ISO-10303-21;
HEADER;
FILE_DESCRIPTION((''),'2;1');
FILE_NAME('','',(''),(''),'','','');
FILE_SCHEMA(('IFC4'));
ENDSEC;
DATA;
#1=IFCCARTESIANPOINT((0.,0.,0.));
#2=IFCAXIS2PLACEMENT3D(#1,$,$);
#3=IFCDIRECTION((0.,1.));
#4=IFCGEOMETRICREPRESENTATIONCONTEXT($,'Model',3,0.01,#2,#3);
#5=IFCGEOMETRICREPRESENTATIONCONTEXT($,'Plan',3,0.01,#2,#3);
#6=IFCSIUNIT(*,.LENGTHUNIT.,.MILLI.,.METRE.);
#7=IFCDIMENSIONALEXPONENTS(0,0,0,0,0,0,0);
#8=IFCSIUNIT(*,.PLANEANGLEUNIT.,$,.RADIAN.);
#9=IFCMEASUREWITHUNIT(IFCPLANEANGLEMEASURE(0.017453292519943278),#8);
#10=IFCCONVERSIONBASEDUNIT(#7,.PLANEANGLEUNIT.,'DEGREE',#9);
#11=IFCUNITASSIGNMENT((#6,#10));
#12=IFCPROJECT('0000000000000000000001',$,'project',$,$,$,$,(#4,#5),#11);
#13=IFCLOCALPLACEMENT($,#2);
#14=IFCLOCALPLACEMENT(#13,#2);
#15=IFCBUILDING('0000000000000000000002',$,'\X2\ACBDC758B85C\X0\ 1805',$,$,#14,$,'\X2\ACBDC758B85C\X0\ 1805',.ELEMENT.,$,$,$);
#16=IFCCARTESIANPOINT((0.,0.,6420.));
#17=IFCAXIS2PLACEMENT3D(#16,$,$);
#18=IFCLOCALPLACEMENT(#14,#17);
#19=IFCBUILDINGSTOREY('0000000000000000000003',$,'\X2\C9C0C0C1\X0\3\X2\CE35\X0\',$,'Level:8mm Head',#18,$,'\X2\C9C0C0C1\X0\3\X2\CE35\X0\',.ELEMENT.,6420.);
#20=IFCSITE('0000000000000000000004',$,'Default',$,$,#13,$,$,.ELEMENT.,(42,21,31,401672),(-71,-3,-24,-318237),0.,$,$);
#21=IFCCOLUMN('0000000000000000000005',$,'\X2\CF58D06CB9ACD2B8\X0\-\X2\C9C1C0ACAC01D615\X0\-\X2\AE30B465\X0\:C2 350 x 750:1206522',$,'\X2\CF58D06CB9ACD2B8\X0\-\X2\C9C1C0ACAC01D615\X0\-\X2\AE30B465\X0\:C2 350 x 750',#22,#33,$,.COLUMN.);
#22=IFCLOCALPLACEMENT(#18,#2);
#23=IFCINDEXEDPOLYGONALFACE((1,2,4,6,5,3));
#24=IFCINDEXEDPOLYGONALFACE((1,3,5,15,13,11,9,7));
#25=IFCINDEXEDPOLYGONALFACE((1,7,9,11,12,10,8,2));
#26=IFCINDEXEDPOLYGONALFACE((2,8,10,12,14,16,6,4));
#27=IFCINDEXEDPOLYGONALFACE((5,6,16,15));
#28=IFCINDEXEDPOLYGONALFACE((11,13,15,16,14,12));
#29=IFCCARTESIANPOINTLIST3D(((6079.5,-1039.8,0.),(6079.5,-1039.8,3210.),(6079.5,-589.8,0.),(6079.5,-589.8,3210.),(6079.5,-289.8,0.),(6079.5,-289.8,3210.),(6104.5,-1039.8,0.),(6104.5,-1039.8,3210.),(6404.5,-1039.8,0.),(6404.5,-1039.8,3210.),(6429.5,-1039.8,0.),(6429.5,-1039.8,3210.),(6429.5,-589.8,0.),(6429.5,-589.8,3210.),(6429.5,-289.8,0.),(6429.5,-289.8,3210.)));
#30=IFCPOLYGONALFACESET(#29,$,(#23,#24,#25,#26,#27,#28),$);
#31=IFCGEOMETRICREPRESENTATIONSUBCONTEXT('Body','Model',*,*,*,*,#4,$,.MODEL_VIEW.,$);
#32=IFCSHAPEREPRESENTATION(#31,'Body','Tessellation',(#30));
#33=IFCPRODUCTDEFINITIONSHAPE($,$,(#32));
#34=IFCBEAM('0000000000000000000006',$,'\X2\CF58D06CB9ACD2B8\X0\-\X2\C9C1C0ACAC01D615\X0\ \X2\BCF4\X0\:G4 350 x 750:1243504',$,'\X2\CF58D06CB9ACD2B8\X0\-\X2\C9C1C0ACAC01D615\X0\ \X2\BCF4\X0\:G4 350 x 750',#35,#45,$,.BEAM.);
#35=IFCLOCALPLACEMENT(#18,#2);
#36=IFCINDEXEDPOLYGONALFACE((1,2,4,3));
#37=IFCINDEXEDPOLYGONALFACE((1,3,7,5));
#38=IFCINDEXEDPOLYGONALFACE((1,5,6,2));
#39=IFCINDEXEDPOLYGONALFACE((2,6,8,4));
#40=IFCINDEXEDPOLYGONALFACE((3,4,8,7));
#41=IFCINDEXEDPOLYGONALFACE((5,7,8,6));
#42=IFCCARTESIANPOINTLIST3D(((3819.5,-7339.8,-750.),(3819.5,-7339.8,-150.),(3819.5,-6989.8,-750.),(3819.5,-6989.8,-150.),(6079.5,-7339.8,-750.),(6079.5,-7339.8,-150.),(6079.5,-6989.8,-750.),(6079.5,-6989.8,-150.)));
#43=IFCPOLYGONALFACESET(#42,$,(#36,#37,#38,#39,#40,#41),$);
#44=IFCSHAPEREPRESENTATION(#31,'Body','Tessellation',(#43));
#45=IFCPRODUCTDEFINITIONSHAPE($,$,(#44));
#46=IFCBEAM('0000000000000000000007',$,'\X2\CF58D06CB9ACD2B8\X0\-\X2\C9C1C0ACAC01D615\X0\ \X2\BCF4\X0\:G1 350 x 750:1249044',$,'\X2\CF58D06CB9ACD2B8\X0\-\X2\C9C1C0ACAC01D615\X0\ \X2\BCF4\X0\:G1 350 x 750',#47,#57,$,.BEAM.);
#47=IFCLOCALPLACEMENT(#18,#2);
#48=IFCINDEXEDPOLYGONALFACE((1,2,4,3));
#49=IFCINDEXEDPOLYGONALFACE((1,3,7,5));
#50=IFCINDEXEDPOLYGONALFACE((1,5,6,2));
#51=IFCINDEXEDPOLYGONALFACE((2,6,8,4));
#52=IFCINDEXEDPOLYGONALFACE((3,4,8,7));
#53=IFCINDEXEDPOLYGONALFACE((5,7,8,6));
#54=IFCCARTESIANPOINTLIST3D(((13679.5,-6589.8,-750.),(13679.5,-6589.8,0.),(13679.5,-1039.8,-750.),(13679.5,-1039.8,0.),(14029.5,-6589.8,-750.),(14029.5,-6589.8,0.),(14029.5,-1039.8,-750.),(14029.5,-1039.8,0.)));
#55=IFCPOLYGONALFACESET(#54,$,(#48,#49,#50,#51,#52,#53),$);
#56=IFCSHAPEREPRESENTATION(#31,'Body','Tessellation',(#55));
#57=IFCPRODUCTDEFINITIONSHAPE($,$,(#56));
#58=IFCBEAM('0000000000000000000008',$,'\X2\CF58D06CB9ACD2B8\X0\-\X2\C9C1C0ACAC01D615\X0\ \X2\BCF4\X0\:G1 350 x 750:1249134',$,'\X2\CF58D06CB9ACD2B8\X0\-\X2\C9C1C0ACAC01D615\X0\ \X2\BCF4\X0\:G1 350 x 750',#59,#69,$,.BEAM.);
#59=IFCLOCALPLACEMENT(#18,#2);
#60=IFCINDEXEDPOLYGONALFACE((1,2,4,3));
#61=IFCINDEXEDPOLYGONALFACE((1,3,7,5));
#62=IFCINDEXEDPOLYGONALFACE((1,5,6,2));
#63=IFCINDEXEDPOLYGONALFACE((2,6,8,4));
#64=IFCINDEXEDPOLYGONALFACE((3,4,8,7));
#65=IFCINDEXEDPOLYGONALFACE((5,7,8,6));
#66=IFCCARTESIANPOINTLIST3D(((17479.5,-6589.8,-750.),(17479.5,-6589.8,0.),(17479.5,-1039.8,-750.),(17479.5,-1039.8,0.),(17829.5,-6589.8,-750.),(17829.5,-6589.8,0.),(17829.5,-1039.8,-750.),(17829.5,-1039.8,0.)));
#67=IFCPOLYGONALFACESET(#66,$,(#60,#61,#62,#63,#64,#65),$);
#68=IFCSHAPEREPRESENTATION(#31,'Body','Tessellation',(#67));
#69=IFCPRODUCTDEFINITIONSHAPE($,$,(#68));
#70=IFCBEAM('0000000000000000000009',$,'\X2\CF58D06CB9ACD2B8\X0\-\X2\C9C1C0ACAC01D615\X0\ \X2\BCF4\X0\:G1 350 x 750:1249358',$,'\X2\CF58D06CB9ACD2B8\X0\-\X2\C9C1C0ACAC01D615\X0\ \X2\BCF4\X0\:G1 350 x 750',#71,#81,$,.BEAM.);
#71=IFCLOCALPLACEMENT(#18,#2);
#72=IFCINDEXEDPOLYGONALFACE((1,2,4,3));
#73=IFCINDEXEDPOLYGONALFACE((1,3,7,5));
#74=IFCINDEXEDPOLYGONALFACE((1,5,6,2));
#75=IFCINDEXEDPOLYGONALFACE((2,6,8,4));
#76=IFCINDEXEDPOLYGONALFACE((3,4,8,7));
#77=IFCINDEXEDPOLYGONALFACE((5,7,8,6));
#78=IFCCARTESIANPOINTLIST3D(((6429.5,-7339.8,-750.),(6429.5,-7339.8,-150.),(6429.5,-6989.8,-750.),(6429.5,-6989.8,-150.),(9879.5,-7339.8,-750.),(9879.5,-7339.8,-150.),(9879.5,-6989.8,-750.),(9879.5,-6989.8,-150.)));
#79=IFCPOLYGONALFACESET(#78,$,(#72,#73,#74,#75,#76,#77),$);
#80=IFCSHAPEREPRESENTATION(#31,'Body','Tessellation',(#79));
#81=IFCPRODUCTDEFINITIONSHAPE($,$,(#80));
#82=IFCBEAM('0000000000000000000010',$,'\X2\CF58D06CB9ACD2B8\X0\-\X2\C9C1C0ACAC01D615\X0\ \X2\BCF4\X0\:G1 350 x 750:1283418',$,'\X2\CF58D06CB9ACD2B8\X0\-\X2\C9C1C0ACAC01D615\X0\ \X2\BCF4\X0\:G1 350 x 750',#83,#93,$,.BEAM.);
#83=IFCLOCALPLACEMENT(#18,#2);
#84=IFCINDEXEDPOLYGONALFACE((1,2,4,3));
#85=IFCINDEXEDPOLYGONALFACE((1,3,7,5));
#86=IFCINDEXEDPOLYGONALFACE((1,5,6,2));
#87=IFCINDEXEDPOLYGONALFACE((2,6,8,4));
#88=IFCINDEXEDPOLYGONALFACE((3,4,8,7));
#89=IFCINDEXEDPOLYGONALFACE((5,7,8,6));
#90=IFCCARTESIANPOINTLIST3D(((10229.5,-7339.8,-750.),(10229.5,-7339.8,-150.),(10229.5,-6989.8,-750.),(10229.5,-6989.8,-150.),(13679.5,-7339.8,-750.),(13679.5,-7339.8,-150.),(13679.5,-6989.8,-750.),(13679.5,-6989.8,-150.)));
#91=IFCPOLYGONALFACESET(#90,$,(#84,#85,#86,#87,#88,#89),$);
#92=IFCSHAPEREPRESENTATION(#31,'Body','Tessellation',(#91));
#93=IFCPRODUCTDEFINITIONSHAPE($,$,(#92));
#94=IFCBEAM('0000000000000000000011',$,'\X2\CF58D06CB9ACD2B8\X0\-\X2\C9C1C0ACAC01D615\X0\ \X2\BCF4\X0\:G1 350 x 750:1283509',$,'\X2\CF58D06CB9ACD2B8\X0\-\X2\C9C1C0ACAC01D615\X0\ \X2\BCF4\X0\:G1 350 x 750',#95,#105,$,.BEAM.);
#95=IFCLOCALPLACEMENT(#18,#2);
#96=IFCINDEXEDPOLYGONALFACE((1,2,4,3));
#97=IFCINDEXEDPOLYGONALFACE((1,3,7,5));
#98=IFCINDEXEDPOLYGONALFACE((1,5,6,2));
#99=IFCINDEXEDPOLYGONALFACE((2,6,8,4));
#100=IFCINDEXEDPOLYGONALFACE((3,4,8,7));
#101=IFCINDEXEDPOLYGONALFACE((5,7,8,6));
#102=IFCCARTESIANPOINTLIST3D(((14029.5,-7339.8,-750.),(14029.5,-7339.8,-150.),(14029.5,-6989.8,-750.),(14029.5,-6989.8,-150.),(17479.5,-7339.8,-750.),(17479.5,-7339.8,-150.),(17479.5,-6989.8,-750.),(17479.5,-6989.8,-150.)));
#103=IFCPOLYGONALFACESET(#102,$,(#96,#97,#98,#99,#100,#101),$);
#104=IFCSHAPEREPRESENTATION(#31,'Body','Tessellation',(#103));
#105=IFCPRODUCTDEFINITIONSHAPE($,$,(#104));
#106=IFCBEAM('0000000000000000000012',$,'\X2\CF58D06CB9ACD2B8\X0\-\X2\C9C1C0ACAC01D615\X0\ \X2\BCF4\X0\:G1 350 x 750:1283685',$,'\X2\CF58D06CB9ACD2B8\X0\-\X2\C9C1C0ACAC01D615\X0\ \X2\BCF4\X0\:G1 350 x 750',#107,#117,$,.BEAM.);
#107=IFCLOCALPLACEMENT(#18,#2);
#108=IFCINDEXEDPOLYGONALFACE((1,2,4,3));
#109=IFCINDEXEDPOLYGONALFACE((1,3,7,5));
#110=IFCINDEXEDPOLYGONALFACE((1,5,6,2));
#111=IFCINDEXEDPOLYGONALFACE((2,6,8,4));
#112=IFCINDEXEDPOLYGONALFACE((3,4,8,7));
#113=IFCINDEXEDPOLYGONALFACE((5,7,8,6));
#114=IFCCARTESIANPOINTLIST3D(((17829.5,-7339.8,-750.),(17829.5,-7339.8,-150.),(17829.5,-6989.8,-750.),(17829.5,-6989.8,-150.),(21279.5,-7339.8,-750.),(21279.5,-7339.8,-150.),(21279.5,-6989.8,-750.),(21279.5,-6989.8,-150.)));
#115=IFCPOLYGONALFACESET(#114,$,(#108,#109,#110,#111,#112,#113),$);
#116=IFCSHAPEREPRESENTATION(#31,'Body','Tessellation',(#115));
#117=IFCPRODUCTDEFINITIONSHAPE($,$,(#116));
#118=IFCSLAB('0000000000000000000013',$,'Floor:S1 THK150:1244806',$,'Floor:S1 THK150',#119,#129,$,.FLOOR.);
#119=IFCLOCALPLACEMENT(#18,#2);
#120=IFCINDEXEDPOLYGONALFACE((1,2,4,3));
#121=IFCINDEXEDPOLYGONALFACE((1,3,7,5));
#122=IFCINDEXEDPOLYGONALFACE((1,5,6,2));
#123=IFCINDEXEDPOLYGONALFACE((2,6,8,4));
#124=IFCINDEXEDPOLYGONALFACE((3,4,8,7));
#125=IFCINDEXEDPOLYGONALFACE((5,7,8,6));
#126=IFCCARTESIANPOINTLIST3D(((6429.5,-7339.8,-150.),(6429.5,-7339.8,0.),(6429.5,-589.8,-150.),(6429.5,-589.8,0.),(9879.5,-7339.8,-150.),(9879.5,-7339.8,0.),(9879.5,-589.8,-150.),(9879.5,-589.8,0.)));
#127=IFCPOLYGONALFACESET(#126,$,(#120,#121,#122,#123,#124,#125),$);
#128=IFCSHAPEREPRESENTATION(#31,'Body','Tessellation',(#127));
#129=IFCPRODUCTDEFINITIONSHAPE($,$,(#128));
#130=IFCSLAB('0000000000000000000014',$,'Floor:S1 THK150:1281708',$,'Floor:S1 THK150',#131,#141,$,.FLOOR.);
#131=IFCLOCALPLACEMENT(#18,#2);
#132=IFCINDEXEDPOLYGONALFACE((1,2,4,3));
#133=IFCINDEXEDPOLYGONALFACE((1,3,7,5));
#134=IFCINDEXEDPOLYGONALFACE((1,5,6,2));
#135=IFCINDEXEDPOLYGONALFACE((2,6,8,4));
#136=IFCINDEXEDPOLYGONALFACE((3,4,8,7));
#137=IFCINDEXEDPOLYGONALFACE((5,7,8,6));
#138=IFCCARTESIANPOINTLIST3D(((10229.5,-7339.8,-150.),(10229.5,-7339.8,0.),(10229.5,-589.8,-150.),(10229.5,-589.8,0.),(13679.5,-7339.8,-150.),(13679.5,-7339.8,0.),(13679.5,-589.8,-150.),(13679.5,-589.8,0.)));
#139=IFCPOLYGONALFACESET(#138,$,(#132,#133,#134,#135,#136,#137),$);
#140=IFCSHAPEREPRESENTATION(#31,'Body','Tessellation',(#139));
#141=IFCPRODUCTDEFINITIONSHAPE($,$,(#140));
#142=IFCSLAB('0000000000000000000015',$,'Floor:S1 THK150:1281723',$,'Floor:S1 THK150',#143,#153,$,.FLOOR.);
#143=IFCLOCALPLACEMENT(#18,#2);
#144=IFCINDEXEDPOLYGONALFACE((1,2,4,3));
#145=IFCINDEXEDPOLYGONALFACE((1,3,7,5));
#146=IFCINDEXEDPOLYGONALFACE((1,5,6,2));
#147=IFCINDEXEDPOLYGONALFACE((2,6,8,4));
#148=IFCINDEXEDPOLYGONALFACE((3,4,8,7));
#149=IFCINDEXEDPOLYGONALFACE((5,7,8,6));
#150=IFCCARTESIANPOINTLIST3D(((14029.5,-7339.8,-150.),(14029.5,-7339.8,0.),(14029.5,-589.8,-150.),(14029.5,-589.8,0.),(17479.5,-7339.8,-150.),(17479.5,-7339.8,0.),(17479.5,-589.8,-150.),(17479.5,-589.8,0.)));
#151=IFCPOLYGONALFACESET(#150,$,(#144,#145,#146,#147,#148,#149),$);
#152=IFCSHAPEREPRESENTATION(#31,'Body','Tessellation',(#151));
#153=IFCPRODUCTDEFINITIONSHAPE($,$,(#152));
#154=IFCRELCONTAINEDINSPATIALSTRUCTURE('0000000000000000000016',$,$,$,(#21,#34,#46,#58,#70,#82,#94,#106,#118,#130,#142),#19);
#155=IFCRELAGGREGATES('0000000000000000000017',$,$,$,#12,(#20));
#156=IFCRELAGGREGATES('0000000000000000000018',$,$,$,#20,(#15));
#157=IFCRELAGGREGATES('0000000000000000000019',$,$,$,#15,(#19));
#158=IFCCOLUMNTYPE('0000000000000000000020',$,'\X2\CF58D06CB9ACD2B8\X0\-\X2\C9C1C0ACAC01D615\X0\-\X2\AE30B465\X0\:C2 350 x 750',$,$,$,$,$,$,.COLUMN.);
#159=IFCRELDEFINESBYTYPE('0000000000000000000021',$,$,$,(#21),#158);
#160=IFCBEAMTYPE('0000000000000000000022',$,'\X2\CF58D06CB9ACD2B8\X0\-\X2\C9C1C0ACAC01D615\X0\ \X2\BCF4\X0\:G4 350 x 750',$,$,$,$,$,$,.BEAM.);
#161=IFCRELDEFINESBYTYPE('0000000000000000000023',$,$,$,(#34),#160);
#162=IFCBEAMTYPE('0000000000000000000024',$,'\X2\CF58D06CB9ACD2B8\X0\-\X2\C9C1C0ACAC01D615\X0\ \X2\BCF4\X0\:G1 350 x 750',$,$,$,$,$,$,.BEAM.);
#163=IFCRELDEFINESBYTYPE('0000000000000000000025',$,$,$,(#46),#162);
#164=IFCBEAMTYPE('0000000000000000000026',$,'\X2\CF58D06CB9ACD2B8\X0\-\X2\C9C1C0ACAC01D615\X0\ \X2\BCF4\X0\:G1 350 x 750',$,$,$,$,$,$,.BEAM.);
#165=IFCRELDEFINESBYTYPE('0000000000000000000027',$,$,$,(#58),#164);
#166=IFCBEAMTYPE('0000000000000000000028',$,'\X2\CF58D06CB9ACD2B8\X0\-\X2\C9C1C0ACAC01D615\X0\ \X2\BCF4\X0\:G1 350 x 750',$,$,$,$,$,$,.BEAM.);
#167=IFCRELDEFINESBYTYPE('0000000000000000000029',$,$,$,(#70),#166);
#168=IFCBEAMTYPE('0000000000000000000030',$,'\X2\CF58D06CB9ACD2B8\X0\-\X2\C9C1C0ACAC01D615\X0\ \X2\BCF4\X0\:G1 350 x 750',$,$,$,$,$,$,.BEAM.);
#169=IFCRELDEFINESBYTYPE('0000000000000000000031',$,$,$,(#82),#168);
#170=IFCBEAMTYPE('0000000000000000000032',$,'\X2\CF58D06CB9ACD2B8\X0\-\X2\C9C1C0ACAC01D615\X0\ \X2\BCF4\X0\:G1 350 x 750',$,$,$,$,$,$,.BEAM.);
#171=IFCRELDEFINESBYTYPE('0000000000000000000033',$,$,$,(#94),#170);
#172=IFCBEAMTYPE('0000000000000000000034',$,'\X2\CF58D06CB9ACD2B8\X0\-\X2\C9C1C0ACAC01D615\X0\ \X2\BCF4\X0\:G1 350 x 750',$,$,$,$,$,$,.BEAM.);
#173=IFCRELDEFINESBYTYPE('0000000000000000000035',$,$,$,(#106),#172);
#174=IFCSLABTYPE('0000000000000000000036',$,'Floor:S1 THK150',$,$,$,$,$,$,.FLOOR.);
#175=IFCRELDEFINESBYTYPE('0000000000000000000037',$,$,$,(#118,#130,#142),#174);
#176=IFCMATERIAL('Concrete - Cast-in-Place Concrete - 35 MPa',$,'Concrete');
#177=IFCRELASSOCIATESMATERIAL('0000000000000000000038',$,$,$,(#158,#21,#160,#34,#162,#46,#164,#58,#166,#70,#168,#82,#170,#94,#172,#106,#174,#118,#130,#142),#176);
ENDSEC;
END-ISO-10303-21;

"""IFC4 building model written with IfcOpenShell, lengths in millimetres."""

from ifc_helpers import new_model, entity, si_unit, converted_unit, direction, frame, origin, place, context, subcontext, project, spatial, indexed_curve, outline, extrude, source, transform, mapped, material, type_object, type_shapes, element, save


model = new_model("IFC4")

# Units and contexts
model_context = context("Model", 3, precision=0.01, world=origin(), true_north=direction((0.0, 1.0)))
plan_context = context("Plan", 3, precision=0.01, world=origin(), true_north=direction((0.0, 1.0)))
body_context = subcontext(model_context, "Body", "Model", "MODEL_VIEW")
ifc_project = project(units=[si_unit("LENGTHUNIT", "METRE", prefix="MILLI"), converted_unit("PLANEANGLEUNIT", "DEGREE", entity("IfcPlaneAngleMeasure", 0.017453292519943278), si_unit("PLANEANGLEUNIT", "RADIAN"), dimensions=[0, 0, 0, 0, 0, 0, 0])], contexts=[model_context, plan_context])

# Site, building, storey
site_placement = place(None, origin())
site = spatial("IfcSite", under=ifc_project, at=site_placement, Name="Default", CompositionType="ELEMENT", RefLatitude=(42, 21, 31, 401672), RefLongitude=(-71, -3, -24, -318237), RefElevation=0.0)
building_placement = place(site_placement, origin())
building = spatial("IfcBuilding", under=site, at=building_placement, Name="경의로 1805", LongName="경의로 1805", CompositionType="ELEMENT")
storey_placement = place(building_placement, frame((0.0, 0.0, 6420.0)))
storey = spatial("IfcBuildingStorey", under=building, at=storey_placement, Name="지상3층", ObjectType="Level:8mm Head", LongName="지상3층", CompositionType="ELEMENT", Elevation=6420.0)

# Column
ifc_material_1 = material(Name="Concrete - Cast-in-Place Concrete - 35 MPa", Category="Concrete")
column_type_1 = type_object("IfcColumnType", Name="콘크리트-직사각형-기둥:C2 350 x 750", PredefinedType="COLUMN", material=ifc_material_1)
shared_shape_1 = source(origin(), body_context, "Body", "SweptSolid", [
    extrude(outline(indexed_curve([(-175.0, -450.0), (175.0, -450.0), (175.0, -150.0), (175.0, 300.0), (150.0, 300.0), (-150.0, 300.0), (-175.0, 300.0), (-175.0, -150.0), (-175.0, -450.0)], self_intersect=False)), frame((6254.5, -739.8, 6420.0), z_axis=(0.0, 0.0, 1.0), x_axis=(-1.0, 0.0, 0.0)), (0.0, 0.0, 1.0), 3210.0),
])
type_shapes(column_type_1, [shared_shape_1])
column_1_placement = place(storey_placement, frame((0.0, 0.0, -6420.0)))
element("IfcColumn", 1, at=column_1_placement, inside=storey, type_object=column_type_1, material=ifc_material_1, Name="콘크리트-직사각형-기둥:C2 350 x 750:1206522", ObjectType="콘크리트-직사각형-기둥:C2 350 x 750", PredefinedType="COLUMN", context=body_context, shape_type="MappedRepresentation", body=[
    mapped(shared_shape_1, transform((0.0, 0.0, 0.0), scale=1.0)),
])

# Beams
beam_type_1 = type_object("IfcBeamType", Name="콘크리트-직사각형 보:G4 350 x 750", PredefinedType="BEAM", material=ifc_material_1)
shared_shape_2 = source(origin(), body_context, "Body", "SweptSolid", [
    extrude(outline(indexed_curve([(-300.0, -175.0), (300.0, -175.0), (300.0, 175.0), (-300.0, 175.0), (-300.0, -175.0)], self_intersect=False)), frame((3819.5, -7164.8, 5970.0), z_axis=(1.0, 0.0, 0.0), x_axis=(0.0, 0.0, -1.0)), (0.0, 0.0, 1.0), 2260.0),
])
type_shapes(beam_type_1, [shared_shape_2])
beam_1_placement = place(storey_placement, frame((0.0, 0.0, -6420.0)))
element("IfcBeam", 2, at=beam_1_placement, inside=storey, type_object=beam_type_1, material=ifc_material_1, Name="콘크리트-직사각형 보:G4 350 x 750:1243504", ObjectType="콘크리트-직사각형 보:G4 350 x 750", PredefinedType="BEAM", context=body_context, shape_type="MappedRepresentation", body=[
    mapped(shared_shape_2, transform((0.0, 0.0, 0.0), scale=1.0)),
])
beam_type_2 = type_object("IfcBeamType", Name="콘크리트-직사각형 보:G1 350 x 750", PredefinedType="BEAM", material=ifc_material_1)
shared_shape_3 = source(origin(), body_context, "Body", "SweptSolid", [
    extrude(outline(indexed_curve([(-175.0, -375.0), (175.0, -375.0), (175.0, 375.0), (-175.0, 375.0), (-175.0, -375.0)], self_intersect=False)), frame((13854.5, -1039.8, 6045.0), z_axis=(0.0, -1.0, 0.0), x_axis=(-1.0, 0.0, 0.0)), (0.0, 0.0, 1.0), 5550.0),
])
type_shapes(beam_type_2, [shared_shape_3])
beam_2_placement = place(storey_placement, frame((0.0, 0.0, -6420.0)))
element("IfcBeam", 3, at=beam_2_placement, inside=storey, type_object=beam_type_2, material=ifc_material_1, Name="콘크리트-직사각형 보:G1 350 x 750:1249044", ObjectType="콘크리트-직사각형 보:G1 350 x 750", PredefinedType="BEAM", context=body_context, shape_type="MappedRepresentation", body=[
    mapped(shared_shape_3, transform((0.0, 0.0, 0.0), scale=1.0)),
])
beam_type_3 = type_object("IfcBeamType", Name="콘크리트-직사각형 보:G1 350 x 750", PredefinedType="BEAM", material=ifc_material_1)
shared_shape_4 = source(origin(), body_context, "Body", "SweptSolid", [
    extrude(outline(indexed_curve([(-175.0, -375.0), (175.0, -375.0), (175.0, 375.0), (-175.0, 375.0), (-175.0, -375.0)], self_intersect=False)), frame((17654.5, -1039.8, 6045.0), z_axis=(0.0, -1.0, 0.0), x_axis=(-1.0, 0.0, 0.0)), (0.0, 0.0, 1.0), 5550.0),
])
type_shapes(beam_type_3, [shared_shape_4])
beam_3_placement = place(storey_placement, frame((0.0, 0.0, -6420.0)))
element("IfcBeam", 4, at=beam_3_placement, inside=storey, type_object=beam_type_3, material=ifc_material_1, Name="콘크리트-직사각형 보:G1 350 x 750:1249134", ObjectType="콘크리트-직사각형 보:G1 350 x 750", PredefinedType="BEAM", context=body_context, shape_type="MappedRepresentation", body=[
    mapped(shared_shape_4, transform((0.0, 0.0, 0.0), scale=1.0)),
])
beam_type_4 = type_object("IfcBeamType", Name="콘크리트-직사각형 보:G1 350 x 750", PredefinedType="BEAM", material=ifc_material_1)
shared_shape_5 = source(origin(), body_context, "Body", "SweptSolid", [
    extrude(outline(indexed_curve([(-300.0, -175.0), (300.0, -175.0), (300.0, 175.0), (-300.0, 175.0), (-300.0, -175.0)], self_intersect=False)), frame((6429.5, -7164.8, 5970.0), z_axis=(1.0, 0.0, 0.0), x_axis=(0.0, 0.0, -1.0)), (0.0, 0.0, 1.0), 3450.0),
])
type_shapes(beam_type_4, [shared_shape_5])
beam_4_placement = place(storey_placement, frame((0.0, 0.0, -6420.0)))
element("IfcBeam", 5, at=beam_4_placement, inside=storey, type_object=beam_type_4, material=ifc_material_1, Name="콘크리트-직사각형 보:G1 350 x 750:1249358", ObjectType="콘크리트-직사각형 보:G1 350 x 750", PredefinedType="BEAM", context=body_context, shape_type="MappedRepresentation", body=[
    mapped(shared_shape_5, transform((0.0, 0.0, 0.0), scale=1.0)),
])
beam_type_5 = type_object("IfcBeamType", Name="콘크리트-직사각형 보:G1 350 x 750", PredefinedType="BEAM", material=ifc_material_1)
shared_shape_6 = source(origin(), body_context, "Body", "SweptSolid", [
    extrude(outline(indexed_curve([(-300.0, -175.0), (300.0, -175.0), (300.0, 175.0), (-300.0, 175.0), (-300.0, -175.0)], self_intersect=False)), frame((10229.5, -7164.8, 5970.0), z_axis=(1.0, 0.0, 0.0), x_axis=(0.0, 0.0, -1.0)), (0.0, 0.0, 1.0), 3450.0),
])
type_shapes(beam_type_5, [shared_shape_6])
beam_5_placement = place(storey_placement, frame((0.0, 0.0, -6420.0)))
element("IfcBeam", 6, at=beam_5_placement, inside=storey, type_object=beam_type_5, material=ifc_material_1, Name="콘크리트-직사각형 보:G1 350 x 750:1283418", ObjectType="콘크리트-직사각형 보:G1 350 x 750", PredefinedType="BEAM", context=body_context, shape_type="MappedRepresentation", body=[
    mapped(shared_shape_6, transform((0.0, 0.0, 0.0), scale=1.0)),
])
beam_type_6 = type_object("IfcBeamType", Name="콘크리트-직사각형 보:G1 350 x 750", PredefinedType="BEAM", material=ifc_material_1)
shared_shape_7 = source(origin(), body_context, "Body", "SweptSolid", [
    extrude(outline(indexed_curve([(-300.0, -175.0), (300.0, -175.0), (300.0, 175.0), (-300.0, 175.0), (-300.0, -175.0)], self_intersect=False)), frame((14029.5, -7164.8, 5970.0), z_axis=(1.0, 0.0, 0.0), x_axis=(0.0, 0.0, -1.0)), (0.0, 0.0, 1.0), 3450.0),
])
type_shapes(beam_type_6, [shared_shape_7])
beam_6_placement = place(storey_placement, frame((0.0, 0.0, -6420.0)))
element("IfcBeam", 7, at=beam_6_placement, inside=storey, type_object=beam_type_6, material=ifc_material_1, Name="콘크리트-직사각형 보:G1 350 x 750:1283509", ObjectType="콘크리트-직사각형 보:G1 350 x 750", PredefinedType="BEAM", context=body_context, shape_type="MappedRepresentation", body=[
    mapped(shared_shape_7, transform((0.0, 0.0, 0.0), scale=1.0)),
])
beam_type_7 = type_object("IfcBeamType", Name="콘크리트-직사각형 보:G1 350 x 750", PredefinedType="BEAM", material=ifc_material_1)
shared_shape_8 = source(origin(), body_context, "Body", "SweptSolid", [
    extrude(outline(indexed_curve([(-300.0, -175.0), (300.0, -175.0), (300.0, 175.0), (-300.0, 175.0), (-300.0, -175.0)], self_intersect=False)), frame((17829.5, -7164.8, 5970.0), z_axis=(1.0, 0.0, 0.0), x_axis=(0.0, 0.0, -1.0)), (0.0, 0.0, 1.0), 3450.0),
])
type_shapes(beam_type_7, [shared_shape_8])
beam_7_placement = place(storey_placement, frame((0.0, 0.0, -6420.0)))
element("IfcBeam", 8, at=beam_7_placement, inside=storey, type_object=beam_type_7, material=ifc_material_1, Name="콘크리트-직사각형 보:G1 350 x 750:1283685", ObjectType="콘크리트-직사각형 보:G1 350 x 750", PredefinedType="BEAM", context=body_context, shape_type="MappedRepresentation", body=[
    mapped(shared_shape_8, transform((0.0, 0.0, 0.0), scale=1.0)),
])

# Slabs
slab_type_1 = type_object("IfcSlabType", Name="Floor:S1 THK150", PredefinedType="FLOOR", material=ifc_material_1)
slab_1_placement = place(storey_placement, origin())
element("IfcSlab", 9, at=slab_1_placement, inside=storey, type_object=slab_type_1, material=ifc_material_1, Name="Floor:S1 THK150:1244806", ObjectType="Floor:S1 THK150", PredefinedType="FLOOR", context=body_context, shape_type="SweptSolid", body=[
    extrude(outline(indexed_curve([(-3375.0, -1725.0), (3375.0, -1725.0), (3375.0, 1725.0), (-3375.0, 1725.0), (-3375.0, -1725.0)], self_intersect=False)), frame((8154.5, -3964.8, 0.0), z_axis=(0.0, 0.0, -1.0), x_axis=(0.0, 1.0, 0.0)), (0.0, 0.0, 1.0), 150.0),
])
slab_2_placement = place(storey_placement, origin())
element("IfcSlab", 10, at=slab_2_placement, inside=storey, type_object=slab_type_1, material=ifc_material_1, Name="Floor:S1 THK150:1281708", ObjectType="Floor:S1 THK150", PredefinedType="FLOOR", context=body_context, shape_type="SweptSolid", body=[
    extrude(outline(indexed_curve([(-3375.0, -1725.0), (3375.0, -1725.0), (3375.0, 1725.0), (-3375.0, 1725.0), (-3375.0, -1725.0)], self_intersect=False)), frame((11954.5, -3964.8, 0.0), z_axis=(0.0, 0.0, -1.0), x_axis=(0.0, 1.0, 0.0)), (0.0, 0.0, 1.0), 150.0),
])
slab_3_placement = place(storey_placement, origin())
element("IfcSlab", 11, at=slab_3_placement, inside=storey, type_object=slab_type_1, material=ifc_material_1, Name="Floor:S1 THK150:1281723", ObjectType="Floor:S1 THK150", PredefinedType="FLOOR", context=body_context, shape_type="SweptSolid", body=[
    extrude(outline(indexed_curve([(-3375.0, -1725.0), (3375.0, -1725.0), (3375.0, 1725.0), (-3375.0, 1725.0), (-3375.0, -1725.0)], self_intersect=False)), frame((15754.5, -3964.8, 0.0), z_axis=(0.0, 0.0, -1.0), x_axis=(0.0, 1.0, 0.0)), (0.0, 0.0, 1.0), 150.0),
])

save(model, "model.ifc")
